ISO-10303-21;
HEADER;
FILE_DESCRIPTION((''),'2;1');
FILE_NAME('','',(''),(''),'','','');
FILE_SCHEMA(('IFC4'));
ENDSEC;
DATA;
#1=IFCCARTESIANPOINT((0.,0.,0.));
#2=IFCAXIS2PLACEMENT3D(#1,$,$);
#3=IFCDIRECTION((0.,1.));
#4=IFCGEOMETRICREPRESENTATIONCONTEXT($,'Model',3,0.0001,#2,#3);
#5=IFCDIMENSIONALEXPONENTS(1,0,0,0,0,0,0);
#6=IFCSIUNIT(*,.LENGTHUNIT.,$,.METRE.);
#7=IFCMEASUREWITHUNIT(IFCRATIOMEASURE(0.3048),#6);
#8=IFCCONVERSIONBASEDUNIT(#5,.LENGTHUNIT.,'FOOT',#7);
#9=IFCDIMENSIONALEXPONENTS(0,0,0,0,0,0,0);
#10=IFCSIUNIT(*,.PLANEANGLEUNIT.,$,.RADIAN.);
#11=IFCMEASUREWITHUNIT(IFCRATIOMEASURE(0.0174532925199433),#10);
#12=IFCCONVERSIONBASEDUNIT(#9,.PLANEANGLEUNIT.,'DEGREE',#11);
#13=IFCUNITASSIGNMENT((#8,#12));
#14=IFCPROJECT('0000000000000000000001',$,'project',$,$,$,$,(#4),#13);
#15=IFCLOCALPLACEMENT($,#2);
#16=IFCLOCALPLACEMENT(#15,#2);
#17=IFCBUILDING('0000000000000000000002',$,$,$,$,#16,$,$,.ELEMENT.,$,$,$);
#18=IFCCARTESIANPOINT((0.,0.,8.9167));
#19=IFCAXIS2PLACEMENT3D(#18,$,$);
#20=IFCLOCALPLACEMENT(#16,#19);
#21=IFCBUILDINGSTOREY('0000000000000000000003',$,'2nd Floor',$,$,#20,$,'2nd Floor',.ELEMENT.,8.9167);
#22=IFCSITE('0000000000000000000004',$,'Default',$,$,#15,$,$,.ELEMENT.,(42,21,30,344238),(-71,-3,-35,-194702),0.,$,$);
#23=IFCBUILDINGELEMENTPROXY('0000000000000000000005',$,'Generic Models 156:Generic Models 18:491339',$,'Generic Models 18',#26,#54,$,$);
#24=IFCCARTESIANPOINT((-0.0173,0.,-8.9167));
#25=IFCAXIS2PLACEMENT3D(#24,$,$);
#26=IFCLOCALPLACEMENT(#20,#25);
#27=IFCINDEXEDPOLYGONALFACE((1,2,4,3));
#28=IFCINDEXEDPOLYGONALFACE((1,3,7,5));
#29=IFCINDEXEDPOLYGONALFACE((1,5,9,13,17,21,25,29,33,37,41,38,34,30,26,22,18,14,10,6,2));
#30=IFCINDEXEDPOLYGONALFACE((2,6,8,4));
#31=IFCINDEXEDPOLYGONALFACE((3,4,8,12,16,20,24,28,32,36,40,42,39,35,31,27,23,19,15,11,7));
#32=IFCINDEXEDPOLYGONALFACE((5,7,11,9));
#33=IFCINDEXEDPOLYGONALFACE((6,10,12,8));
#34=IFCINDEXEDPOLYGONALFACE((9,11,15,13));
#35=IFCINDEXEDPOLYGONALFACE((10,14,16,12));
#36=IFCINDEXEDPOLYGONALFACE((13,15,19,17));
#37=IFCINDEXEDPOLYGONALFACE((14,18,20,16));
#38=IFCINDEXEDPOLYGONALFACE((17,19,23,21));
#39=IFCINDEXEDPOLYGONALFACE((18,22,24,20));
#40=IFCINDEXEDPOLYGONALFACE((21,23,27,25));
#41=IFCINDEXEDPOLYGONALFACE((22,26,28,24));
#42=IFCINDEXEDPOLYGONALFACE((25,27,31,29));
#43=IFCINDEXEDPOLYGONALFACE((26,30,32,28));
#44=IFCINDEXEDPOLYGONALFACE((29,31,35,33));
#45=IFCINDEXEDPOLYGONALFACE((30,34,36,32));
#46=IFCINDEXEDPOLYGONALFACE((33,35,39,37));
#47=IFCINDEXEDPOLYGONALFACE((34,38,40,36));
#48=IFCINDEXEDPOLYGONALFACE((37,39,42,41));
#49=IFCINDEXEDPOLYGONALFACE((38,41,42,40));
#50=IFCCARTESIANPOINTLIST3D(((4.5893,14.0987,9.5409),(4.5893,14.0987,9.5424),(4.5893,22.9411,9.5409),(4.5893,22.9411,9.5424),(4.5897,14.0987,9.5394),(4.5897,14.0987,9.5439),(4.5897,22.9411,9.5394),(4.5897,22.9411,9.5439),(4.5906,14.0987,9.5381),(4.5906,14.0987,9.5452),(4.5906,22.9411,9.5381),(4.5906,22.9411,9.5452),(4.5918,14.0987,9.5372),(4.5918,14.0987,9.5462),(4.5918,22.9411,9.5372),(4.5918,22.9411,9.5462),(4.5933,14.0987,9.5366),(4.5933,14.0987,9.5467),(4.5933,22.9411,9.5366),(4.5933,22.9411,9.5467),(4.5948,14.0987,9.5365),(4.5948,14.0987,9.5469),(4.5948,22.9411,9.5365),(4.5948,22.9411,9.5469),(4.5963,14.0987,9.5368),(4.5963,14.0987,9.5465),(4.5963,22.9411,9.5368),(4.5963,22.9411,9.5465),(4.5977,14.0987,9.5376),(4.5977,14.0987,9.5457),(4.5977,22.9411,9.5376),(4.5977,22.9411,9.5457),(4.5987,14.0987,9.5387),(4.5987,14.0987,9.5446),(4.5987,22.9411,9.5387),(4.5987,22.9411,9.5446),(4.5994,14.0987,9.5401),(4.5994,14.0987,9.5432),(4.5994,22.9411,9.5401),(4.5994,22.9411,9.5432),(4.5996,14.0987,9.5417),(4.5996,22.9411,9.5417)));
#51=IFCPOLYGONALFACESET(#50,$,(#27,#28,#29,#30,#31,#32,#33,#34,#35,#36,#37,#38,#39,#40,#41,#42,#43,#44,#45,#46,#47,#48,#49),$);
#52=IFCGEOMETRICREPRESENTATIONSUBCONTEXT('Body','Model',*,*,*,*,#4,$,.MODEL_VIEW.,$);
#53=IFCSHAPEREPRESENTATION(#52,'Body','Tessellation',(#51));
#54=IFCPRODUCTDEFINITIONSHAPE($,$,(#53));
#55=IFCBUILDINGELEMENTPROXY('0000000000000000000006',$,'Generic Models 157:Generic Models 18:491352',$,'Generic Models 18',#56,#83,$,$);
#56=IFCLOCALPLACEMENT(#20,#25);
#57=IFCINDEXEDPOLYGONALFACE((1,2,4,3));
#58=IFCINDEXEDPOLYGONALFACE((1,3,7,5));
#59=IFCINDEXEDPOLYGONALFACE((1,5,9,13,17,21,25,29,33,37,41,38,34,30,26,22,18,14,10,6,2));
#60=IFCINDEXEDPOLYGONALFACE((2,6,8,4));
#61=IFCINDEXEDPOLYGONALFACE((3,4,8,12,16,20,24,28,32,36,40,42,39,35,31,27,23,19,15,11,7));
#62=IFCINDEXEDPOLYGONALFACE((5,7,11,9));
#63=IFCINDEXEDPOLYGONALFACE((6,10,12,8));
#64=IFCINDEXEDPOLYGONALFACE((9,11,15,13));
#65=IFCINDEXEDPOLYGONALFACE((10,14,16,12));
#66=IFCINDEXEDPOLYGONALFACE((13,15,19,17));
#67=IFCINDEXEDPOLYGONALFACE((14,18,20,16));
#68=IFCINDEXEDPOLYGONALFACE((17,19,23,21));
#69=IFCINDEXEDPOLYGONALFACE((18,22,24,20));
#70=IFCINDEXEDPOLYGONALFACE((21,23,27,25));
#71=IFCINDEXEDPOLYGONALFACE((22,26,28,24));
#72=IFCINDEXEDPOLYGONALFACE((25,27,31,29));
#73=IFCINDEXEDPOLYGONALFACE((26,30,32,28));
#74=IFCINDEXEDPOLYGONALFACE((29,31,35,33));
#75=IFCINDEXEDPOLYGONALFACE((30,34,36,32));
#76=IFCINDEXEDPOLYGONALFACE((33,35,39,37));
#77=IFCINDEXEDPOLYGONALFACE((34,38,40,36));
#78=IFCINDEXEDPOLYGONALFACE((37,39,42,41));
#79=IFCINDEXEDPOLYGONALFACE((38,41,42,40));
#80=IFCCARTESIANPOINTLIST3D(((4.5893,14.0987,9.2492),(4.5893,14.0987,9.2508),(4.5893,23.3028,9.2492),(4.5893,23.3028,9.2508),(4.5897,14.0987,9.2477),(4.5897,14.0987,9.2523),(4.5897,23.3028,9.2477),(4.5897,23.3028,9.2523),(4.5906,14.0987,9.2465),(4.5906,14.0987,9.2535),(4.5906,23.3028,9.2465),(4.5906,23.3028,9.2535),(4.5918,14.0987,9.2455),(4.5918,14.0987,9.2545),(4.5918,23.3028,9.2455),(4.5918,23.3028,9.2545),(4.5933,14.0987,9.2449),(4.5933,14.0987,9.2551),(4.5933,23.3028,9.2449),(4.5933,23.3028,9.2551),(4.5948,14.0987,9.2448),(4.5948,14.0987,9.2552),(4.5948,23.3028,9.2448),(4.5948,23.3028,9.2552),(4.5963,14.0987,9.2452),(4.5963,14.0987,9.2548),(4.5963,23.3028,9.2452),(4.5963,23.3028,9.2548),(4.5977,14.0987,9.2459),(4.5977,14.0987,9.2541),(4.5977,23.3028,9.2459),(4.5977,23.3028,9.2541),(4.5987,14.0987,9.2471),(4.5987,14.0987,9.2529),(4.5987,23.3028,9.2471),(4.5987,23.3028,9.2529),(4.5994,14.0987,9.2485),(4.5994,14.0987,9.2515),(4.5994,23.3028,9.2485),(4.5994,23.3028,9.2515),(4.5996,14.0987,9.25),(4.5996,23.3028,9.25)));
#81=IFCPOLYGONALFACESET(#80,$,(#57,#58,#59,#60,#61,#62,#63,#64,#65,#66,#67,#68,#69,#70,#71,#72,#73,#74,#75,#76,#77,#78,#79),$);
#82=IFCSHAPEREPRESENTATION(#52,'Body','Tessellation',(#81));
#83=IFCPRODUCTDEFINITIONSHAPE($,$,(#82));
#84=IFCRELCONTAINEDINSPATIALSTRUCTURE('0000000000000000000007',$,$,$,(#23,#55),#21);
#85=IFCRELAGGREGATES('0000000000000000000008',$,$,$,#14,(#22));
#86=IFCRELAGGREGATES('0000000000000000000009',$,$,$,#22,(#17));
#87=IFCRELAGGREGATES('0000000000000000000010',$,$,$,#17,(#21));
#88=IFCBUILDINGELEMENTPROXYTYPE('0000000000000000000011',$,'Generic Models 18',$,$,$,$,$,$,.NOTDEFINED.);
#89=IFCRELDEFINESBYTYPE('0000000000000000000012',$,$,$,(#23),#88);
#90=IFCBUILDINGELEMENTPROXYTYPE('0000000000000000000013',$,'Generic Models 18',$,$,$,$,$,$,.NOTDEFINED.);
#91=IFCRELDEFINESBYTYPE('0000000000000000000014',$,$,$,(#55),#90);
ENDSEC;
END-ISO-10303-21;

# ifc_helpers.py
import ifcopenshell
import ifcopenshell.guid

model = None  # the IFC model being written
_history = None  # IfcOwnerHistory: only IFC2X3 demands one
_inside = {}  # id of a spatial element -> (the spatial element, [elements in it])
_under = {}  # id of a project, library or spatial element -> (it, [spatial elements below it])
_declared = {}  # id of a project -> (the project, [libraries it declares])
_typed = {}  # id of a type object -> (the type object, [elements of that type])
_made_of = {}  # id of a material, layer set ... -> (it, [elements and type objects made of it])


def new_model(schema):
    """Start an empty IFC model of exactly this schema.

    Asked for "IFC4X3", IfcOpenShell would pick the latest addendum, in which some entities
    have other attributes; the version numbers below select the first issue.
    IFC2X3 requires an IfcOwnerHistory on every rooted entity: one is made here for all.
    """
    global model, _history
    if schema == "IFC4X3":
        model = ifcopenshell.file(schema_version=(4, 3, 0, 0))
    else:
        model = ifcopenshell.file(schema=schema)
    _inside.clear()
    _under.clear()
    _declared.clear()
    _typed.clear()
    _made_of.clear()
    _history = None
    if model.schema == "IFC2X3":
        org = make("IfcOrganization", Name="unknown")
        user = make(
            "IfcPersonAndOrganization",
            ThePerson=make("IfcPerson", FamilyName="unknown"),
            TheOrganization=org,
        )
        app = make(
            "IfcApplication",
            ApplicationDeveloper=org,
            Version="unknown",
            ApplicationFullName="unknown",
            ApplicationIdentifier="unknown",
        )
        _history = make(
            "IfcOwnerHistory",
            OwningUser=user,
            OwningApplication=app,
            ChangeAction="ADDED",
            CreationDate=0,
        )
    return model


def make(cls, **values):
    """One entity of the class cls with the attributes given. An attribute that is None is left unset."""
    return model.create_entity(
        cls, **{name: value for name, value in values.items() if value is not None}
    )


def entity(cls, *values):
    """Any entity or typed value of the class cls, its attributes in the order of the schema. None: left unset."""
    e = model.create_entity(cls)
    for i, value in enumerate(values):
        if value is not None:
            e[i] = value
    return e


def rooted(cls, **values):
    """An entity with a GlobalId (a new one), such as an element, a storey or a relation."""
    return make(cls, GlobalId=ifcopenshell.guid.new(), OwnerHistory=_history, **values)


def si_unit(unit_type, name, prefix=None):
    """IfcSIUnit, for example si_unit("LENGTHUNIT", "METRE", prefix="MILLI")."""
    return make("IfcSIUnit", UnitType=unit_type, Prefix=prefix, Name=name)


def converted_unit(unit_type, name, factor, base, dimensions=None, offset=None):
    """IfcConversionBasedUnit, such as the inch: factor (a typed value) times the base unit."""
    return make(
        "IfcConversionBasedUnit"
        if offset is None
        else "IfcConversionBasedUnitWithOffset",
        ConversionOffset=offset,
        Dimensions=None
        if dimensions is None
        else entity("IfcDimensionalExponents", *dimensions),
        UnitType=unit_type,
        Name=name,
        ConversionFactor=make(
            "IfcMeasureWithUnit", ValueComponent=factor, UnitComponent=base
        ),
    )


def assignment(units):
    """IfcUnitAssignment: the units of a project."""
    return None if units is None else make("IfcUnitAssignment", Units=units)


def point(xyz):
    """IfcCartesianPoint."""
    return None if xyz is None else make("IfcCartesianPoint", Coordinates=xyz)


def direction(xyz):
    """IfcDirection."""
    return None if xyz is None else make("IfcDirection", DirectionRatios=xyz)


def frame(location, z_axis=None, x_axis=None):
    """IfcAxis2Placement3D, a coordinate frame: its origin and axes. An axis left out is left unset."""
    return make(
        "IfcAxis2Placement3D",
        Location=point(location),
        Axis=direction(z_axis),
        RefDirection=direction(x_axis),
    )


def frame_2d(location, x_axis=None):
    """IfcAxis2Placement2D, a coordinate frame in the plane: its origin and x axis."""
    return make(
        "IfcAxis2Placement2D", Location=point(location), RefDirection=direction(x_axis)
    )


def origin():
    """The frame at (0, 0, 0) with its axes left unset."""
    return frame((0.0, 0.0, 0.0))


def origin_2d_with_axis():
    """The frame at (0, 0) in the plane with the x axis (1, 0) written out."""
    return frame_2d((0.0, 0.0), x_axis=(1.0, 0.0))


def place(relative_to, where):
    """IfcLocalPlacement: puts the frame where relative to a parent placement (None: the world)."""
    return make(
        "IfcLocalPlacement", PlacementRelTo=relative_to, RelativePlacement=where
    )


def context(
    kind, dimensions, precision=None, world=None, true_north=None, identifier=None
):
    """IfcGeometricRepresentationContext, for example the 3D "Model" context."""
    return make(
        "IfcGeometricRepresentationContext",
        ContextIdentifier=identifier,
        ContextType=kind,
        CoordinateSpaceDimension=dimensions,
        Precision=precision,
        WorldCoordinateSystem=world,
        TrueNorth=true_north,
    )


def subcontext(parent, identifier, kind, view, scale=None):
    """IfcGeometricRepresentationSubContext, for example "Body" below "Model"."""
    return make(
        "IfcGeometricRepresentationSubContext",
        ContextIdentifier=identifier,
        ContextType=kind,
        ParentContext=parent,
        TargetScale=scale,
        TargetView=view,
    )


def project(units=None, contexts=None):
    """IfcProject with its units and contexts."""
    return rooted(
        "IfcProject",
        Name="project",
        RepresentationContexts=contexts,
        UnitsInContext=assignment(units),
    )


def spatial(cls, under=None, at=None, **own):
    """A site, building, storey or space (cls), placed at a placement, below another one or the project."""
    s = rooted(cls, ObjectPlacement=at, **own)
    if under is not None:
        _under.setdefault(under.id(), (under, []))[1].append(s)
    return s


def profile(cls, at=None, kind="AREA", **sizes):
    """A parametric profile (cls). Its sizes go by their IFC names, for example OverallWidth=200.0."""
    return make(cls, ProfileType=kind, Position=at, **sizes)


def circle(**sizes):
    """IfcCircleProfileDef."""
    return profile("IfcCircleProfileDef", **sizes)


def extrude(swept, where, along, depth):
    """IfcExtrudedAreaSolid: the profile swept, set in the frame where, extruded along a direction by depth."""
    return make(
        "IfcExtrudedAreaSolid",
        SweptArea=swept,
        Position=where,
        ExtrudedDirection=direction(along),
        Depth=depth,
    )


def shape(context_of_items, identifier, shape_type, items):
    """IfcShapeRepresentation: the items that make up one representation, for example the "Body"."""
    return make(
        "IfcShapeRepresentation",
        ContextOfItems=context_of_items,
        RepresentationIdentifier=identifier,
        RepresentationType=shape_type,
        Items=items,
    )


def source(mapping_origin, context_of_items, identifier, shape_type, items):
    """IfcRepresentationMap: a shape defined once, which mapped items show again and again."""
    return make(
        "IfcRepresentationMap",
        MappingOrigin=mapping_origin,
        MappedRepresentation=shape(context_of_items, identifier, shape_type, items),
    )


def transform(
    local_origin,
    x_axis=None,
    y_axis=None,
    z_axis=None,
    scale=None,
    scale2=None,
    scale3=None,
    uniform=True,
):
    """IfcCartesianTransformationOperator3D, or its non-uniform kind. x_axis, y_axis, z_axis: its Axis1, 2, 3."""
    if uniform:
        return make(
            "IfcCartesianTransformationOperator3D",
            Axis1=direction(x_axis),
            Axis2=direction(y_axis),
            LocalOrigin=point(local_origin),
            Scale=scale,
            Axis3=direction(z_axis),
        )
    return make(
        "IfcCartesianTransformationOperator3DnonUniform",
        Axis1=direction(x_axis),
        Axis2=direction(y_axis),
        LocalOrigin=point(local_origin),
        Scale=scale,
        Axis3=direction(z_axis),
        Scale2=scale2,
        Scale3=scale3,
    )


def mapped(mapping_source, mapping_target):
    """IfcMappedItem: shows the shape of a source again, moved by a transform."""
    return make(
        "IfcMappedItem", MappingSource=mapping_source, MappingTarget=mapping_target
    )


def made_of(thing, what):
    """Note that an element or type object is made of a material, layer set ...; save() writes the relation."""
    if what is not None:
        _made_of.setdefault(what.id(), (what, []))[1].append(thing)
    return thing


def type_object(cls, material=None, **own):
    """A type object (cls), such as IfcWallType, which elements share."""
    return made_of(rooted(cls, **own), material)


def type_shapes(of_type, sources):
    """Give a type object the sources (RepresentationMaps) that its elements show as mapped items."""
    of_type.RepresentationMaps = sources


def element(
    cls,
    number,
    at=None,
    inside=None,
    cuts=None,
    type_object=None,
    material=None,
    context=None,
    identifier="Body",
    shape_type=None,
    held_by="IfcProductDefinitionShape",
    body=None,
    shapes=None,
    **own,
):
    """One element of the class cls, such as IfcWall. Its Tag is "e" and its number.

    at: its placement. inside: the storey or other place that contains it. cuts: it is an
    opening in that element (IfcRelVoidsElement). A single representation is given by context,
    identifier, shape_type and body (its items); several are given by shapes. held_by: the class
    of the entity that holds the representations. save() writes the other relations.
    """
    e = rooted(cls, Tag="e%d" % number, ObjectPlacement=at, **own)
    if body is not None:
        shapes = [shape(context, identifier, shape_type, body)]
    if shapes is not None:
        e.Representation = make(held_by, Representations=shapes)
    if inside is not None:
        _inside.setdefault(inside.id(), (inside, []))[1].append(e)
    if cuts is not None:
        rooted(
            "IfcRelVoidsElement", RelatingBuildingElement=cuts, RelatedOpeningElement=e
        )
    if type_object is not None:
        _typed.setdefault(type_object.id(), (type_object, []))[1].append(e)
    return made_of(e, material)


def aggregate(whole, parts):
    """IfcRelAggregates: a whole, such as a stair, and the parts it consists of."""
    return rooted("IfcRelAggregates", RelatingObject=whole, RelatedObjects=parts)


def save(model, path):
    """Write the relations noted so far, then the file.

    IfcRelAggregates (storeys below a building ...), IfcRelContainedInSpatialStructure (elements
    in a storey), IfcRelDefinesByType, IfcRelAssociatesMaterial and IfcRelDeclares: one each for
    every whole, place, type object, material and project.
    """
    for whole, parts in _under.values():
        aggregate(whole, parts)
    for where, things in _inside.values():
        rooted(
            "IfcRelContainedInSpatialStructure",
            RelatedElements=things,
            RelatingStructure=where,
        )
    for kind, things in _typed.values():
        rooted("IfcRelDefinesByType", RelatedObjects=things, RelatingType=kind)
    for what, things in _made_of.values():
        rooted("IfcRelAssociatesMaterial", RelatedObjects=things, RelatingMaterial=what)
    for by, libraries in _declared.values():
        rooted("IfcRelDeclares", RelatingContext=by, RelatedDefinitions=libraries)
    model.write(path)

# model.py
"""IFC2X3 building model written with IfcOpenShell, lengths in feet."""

from ifc_helpers import new_model, entity, si_unit, converted_unit, direction, frame, origin, origin_2d_with_axis, place, context, subcontext, project, spatial, circle, extrude, source, transform, mapped, type_object, type_shapes, element, save


model = new_model("IFC2X3")

# Units and contexts
model_context = context("Model", 3, precision=0.0001, world=origin(), true_north=direction((0.0, 1.0)))
body_context = subcontext(model_context, "Body", "Model", "MODEL_VIEW")
ifc_project = project(units=[converted_unit("LENGTHUNIT", "FOOT", entity("IfcRatioMeasure", 0.3048), si_unit("LENGTHUNIT", "METRE"), dimensions=[1, 0, 0, 0, 0, 0, 0]), converted_unit("PLANEANGLEUNIT", "DEGREE", entity("IfcRatioMeasure", 0.0174532925199433), si_unit("PLANEANGLEUNIT", "RADIAN"), dimensions=[0, 0, 0, 0, 0, 0, 0])], contexts=[model_context])

# Site, building, storey
site_placement = place(None, origin())
site = spatial("IfcSite", under=ifc_project, at=site_placement, Name="Default", CompositionType="ELEMENT", RefLatitude=(42, 21, 30, 344238), RefLongitude=(-71, -3, -35, -194702), RefElevation=0.0)
building_placement = place(site_placement, origin())
building = spatial("IfcBuilding", under=site, at=building_placement, CompositionType="ELEMENT")
storey_placement = place(building_placement, frame((0.0, 0.0, 8.9167)))
storey = spatial("IfcBuildingStorey", under=building, at=storey_placement, Name="2nd Floor", LongName="2nd Floor", CompositionType="ELEMENT", Elevation=8.9167)

# Building element proxies
building_element_proxy_type_1 = type_object("IfcBuildingElementProxyType", Name="Generic Models 18", PredefinedType="NOTDEFINED")
shared_shape_1 = source(origin(), body_context, "Body", "SweptSolid", [
    extrude(circle(Radius=0.0052, at=origin_2d_with_axis()), frame((4.5944, 14.0987, 9.5417), z_axis=(0.0, 1.0, 0.0), x_axis=(1.0, 0.0, 0.0)), (0.0, 0.0, 1.0), 8.8424),
])
type_shapes(building_element_proxy_type_1, [shared_shape_1])
proxy_1_placement = place(storey_placement, frame((-0.0173, 0.0, -8.9167)))
element("IfcBuildingElementProxy", 1, at=proxy_1_placement, inside=storey, type_object=building_element_proxy_type_1, Name="Generic Models 156:Generic Models 18:491339", ObjectType="Generic Models 18", context=body_context, shape_type="MappedRepresentation", body=[
    mapped(shared_shape_1, transform((0.0, 0.0, 0.0), scale=1.0)),
])
building_element_proxy_type_2 = type_object("IfcBuildingElementProxyType", Name="Generic Models 18", PredefinedType="NOTDEFINED")
shared_shape_2 = source(origin(), body_context, "Body", "SweptSolid", [
    extrude(circle(Radius=0.0052, at=origin_2d_with_axis()), frame((4.5944, 14.0987, 9.25), z_axis=(0.0, 1.0, 0.0), x_axis=(1.0, 0.0, 0.0)), (0.0, 0.0, 1.0), 9.2041),
])
type_shapes(building_element_proxy_type_2, [shared_shape_2])
proxy_2_placement = place(storey_placement, frame((-0.0173, 0.0, -8.9167)))
element("IfcBuildingElementProxy", 2, at=proxy_2_placement, inside=storey, type_object=building_element_proxy_type_2, Name="Generic Models 157:Generic Models 18:491352", ObjectType="Generic Models 18", context=body_context, shape_type="MappedRepresentation", body=[
    mapped(shared_shape_2, transform((0.0, 0.0, 0.0), scale=1.0)),
])

save(model, "model.ifc")
